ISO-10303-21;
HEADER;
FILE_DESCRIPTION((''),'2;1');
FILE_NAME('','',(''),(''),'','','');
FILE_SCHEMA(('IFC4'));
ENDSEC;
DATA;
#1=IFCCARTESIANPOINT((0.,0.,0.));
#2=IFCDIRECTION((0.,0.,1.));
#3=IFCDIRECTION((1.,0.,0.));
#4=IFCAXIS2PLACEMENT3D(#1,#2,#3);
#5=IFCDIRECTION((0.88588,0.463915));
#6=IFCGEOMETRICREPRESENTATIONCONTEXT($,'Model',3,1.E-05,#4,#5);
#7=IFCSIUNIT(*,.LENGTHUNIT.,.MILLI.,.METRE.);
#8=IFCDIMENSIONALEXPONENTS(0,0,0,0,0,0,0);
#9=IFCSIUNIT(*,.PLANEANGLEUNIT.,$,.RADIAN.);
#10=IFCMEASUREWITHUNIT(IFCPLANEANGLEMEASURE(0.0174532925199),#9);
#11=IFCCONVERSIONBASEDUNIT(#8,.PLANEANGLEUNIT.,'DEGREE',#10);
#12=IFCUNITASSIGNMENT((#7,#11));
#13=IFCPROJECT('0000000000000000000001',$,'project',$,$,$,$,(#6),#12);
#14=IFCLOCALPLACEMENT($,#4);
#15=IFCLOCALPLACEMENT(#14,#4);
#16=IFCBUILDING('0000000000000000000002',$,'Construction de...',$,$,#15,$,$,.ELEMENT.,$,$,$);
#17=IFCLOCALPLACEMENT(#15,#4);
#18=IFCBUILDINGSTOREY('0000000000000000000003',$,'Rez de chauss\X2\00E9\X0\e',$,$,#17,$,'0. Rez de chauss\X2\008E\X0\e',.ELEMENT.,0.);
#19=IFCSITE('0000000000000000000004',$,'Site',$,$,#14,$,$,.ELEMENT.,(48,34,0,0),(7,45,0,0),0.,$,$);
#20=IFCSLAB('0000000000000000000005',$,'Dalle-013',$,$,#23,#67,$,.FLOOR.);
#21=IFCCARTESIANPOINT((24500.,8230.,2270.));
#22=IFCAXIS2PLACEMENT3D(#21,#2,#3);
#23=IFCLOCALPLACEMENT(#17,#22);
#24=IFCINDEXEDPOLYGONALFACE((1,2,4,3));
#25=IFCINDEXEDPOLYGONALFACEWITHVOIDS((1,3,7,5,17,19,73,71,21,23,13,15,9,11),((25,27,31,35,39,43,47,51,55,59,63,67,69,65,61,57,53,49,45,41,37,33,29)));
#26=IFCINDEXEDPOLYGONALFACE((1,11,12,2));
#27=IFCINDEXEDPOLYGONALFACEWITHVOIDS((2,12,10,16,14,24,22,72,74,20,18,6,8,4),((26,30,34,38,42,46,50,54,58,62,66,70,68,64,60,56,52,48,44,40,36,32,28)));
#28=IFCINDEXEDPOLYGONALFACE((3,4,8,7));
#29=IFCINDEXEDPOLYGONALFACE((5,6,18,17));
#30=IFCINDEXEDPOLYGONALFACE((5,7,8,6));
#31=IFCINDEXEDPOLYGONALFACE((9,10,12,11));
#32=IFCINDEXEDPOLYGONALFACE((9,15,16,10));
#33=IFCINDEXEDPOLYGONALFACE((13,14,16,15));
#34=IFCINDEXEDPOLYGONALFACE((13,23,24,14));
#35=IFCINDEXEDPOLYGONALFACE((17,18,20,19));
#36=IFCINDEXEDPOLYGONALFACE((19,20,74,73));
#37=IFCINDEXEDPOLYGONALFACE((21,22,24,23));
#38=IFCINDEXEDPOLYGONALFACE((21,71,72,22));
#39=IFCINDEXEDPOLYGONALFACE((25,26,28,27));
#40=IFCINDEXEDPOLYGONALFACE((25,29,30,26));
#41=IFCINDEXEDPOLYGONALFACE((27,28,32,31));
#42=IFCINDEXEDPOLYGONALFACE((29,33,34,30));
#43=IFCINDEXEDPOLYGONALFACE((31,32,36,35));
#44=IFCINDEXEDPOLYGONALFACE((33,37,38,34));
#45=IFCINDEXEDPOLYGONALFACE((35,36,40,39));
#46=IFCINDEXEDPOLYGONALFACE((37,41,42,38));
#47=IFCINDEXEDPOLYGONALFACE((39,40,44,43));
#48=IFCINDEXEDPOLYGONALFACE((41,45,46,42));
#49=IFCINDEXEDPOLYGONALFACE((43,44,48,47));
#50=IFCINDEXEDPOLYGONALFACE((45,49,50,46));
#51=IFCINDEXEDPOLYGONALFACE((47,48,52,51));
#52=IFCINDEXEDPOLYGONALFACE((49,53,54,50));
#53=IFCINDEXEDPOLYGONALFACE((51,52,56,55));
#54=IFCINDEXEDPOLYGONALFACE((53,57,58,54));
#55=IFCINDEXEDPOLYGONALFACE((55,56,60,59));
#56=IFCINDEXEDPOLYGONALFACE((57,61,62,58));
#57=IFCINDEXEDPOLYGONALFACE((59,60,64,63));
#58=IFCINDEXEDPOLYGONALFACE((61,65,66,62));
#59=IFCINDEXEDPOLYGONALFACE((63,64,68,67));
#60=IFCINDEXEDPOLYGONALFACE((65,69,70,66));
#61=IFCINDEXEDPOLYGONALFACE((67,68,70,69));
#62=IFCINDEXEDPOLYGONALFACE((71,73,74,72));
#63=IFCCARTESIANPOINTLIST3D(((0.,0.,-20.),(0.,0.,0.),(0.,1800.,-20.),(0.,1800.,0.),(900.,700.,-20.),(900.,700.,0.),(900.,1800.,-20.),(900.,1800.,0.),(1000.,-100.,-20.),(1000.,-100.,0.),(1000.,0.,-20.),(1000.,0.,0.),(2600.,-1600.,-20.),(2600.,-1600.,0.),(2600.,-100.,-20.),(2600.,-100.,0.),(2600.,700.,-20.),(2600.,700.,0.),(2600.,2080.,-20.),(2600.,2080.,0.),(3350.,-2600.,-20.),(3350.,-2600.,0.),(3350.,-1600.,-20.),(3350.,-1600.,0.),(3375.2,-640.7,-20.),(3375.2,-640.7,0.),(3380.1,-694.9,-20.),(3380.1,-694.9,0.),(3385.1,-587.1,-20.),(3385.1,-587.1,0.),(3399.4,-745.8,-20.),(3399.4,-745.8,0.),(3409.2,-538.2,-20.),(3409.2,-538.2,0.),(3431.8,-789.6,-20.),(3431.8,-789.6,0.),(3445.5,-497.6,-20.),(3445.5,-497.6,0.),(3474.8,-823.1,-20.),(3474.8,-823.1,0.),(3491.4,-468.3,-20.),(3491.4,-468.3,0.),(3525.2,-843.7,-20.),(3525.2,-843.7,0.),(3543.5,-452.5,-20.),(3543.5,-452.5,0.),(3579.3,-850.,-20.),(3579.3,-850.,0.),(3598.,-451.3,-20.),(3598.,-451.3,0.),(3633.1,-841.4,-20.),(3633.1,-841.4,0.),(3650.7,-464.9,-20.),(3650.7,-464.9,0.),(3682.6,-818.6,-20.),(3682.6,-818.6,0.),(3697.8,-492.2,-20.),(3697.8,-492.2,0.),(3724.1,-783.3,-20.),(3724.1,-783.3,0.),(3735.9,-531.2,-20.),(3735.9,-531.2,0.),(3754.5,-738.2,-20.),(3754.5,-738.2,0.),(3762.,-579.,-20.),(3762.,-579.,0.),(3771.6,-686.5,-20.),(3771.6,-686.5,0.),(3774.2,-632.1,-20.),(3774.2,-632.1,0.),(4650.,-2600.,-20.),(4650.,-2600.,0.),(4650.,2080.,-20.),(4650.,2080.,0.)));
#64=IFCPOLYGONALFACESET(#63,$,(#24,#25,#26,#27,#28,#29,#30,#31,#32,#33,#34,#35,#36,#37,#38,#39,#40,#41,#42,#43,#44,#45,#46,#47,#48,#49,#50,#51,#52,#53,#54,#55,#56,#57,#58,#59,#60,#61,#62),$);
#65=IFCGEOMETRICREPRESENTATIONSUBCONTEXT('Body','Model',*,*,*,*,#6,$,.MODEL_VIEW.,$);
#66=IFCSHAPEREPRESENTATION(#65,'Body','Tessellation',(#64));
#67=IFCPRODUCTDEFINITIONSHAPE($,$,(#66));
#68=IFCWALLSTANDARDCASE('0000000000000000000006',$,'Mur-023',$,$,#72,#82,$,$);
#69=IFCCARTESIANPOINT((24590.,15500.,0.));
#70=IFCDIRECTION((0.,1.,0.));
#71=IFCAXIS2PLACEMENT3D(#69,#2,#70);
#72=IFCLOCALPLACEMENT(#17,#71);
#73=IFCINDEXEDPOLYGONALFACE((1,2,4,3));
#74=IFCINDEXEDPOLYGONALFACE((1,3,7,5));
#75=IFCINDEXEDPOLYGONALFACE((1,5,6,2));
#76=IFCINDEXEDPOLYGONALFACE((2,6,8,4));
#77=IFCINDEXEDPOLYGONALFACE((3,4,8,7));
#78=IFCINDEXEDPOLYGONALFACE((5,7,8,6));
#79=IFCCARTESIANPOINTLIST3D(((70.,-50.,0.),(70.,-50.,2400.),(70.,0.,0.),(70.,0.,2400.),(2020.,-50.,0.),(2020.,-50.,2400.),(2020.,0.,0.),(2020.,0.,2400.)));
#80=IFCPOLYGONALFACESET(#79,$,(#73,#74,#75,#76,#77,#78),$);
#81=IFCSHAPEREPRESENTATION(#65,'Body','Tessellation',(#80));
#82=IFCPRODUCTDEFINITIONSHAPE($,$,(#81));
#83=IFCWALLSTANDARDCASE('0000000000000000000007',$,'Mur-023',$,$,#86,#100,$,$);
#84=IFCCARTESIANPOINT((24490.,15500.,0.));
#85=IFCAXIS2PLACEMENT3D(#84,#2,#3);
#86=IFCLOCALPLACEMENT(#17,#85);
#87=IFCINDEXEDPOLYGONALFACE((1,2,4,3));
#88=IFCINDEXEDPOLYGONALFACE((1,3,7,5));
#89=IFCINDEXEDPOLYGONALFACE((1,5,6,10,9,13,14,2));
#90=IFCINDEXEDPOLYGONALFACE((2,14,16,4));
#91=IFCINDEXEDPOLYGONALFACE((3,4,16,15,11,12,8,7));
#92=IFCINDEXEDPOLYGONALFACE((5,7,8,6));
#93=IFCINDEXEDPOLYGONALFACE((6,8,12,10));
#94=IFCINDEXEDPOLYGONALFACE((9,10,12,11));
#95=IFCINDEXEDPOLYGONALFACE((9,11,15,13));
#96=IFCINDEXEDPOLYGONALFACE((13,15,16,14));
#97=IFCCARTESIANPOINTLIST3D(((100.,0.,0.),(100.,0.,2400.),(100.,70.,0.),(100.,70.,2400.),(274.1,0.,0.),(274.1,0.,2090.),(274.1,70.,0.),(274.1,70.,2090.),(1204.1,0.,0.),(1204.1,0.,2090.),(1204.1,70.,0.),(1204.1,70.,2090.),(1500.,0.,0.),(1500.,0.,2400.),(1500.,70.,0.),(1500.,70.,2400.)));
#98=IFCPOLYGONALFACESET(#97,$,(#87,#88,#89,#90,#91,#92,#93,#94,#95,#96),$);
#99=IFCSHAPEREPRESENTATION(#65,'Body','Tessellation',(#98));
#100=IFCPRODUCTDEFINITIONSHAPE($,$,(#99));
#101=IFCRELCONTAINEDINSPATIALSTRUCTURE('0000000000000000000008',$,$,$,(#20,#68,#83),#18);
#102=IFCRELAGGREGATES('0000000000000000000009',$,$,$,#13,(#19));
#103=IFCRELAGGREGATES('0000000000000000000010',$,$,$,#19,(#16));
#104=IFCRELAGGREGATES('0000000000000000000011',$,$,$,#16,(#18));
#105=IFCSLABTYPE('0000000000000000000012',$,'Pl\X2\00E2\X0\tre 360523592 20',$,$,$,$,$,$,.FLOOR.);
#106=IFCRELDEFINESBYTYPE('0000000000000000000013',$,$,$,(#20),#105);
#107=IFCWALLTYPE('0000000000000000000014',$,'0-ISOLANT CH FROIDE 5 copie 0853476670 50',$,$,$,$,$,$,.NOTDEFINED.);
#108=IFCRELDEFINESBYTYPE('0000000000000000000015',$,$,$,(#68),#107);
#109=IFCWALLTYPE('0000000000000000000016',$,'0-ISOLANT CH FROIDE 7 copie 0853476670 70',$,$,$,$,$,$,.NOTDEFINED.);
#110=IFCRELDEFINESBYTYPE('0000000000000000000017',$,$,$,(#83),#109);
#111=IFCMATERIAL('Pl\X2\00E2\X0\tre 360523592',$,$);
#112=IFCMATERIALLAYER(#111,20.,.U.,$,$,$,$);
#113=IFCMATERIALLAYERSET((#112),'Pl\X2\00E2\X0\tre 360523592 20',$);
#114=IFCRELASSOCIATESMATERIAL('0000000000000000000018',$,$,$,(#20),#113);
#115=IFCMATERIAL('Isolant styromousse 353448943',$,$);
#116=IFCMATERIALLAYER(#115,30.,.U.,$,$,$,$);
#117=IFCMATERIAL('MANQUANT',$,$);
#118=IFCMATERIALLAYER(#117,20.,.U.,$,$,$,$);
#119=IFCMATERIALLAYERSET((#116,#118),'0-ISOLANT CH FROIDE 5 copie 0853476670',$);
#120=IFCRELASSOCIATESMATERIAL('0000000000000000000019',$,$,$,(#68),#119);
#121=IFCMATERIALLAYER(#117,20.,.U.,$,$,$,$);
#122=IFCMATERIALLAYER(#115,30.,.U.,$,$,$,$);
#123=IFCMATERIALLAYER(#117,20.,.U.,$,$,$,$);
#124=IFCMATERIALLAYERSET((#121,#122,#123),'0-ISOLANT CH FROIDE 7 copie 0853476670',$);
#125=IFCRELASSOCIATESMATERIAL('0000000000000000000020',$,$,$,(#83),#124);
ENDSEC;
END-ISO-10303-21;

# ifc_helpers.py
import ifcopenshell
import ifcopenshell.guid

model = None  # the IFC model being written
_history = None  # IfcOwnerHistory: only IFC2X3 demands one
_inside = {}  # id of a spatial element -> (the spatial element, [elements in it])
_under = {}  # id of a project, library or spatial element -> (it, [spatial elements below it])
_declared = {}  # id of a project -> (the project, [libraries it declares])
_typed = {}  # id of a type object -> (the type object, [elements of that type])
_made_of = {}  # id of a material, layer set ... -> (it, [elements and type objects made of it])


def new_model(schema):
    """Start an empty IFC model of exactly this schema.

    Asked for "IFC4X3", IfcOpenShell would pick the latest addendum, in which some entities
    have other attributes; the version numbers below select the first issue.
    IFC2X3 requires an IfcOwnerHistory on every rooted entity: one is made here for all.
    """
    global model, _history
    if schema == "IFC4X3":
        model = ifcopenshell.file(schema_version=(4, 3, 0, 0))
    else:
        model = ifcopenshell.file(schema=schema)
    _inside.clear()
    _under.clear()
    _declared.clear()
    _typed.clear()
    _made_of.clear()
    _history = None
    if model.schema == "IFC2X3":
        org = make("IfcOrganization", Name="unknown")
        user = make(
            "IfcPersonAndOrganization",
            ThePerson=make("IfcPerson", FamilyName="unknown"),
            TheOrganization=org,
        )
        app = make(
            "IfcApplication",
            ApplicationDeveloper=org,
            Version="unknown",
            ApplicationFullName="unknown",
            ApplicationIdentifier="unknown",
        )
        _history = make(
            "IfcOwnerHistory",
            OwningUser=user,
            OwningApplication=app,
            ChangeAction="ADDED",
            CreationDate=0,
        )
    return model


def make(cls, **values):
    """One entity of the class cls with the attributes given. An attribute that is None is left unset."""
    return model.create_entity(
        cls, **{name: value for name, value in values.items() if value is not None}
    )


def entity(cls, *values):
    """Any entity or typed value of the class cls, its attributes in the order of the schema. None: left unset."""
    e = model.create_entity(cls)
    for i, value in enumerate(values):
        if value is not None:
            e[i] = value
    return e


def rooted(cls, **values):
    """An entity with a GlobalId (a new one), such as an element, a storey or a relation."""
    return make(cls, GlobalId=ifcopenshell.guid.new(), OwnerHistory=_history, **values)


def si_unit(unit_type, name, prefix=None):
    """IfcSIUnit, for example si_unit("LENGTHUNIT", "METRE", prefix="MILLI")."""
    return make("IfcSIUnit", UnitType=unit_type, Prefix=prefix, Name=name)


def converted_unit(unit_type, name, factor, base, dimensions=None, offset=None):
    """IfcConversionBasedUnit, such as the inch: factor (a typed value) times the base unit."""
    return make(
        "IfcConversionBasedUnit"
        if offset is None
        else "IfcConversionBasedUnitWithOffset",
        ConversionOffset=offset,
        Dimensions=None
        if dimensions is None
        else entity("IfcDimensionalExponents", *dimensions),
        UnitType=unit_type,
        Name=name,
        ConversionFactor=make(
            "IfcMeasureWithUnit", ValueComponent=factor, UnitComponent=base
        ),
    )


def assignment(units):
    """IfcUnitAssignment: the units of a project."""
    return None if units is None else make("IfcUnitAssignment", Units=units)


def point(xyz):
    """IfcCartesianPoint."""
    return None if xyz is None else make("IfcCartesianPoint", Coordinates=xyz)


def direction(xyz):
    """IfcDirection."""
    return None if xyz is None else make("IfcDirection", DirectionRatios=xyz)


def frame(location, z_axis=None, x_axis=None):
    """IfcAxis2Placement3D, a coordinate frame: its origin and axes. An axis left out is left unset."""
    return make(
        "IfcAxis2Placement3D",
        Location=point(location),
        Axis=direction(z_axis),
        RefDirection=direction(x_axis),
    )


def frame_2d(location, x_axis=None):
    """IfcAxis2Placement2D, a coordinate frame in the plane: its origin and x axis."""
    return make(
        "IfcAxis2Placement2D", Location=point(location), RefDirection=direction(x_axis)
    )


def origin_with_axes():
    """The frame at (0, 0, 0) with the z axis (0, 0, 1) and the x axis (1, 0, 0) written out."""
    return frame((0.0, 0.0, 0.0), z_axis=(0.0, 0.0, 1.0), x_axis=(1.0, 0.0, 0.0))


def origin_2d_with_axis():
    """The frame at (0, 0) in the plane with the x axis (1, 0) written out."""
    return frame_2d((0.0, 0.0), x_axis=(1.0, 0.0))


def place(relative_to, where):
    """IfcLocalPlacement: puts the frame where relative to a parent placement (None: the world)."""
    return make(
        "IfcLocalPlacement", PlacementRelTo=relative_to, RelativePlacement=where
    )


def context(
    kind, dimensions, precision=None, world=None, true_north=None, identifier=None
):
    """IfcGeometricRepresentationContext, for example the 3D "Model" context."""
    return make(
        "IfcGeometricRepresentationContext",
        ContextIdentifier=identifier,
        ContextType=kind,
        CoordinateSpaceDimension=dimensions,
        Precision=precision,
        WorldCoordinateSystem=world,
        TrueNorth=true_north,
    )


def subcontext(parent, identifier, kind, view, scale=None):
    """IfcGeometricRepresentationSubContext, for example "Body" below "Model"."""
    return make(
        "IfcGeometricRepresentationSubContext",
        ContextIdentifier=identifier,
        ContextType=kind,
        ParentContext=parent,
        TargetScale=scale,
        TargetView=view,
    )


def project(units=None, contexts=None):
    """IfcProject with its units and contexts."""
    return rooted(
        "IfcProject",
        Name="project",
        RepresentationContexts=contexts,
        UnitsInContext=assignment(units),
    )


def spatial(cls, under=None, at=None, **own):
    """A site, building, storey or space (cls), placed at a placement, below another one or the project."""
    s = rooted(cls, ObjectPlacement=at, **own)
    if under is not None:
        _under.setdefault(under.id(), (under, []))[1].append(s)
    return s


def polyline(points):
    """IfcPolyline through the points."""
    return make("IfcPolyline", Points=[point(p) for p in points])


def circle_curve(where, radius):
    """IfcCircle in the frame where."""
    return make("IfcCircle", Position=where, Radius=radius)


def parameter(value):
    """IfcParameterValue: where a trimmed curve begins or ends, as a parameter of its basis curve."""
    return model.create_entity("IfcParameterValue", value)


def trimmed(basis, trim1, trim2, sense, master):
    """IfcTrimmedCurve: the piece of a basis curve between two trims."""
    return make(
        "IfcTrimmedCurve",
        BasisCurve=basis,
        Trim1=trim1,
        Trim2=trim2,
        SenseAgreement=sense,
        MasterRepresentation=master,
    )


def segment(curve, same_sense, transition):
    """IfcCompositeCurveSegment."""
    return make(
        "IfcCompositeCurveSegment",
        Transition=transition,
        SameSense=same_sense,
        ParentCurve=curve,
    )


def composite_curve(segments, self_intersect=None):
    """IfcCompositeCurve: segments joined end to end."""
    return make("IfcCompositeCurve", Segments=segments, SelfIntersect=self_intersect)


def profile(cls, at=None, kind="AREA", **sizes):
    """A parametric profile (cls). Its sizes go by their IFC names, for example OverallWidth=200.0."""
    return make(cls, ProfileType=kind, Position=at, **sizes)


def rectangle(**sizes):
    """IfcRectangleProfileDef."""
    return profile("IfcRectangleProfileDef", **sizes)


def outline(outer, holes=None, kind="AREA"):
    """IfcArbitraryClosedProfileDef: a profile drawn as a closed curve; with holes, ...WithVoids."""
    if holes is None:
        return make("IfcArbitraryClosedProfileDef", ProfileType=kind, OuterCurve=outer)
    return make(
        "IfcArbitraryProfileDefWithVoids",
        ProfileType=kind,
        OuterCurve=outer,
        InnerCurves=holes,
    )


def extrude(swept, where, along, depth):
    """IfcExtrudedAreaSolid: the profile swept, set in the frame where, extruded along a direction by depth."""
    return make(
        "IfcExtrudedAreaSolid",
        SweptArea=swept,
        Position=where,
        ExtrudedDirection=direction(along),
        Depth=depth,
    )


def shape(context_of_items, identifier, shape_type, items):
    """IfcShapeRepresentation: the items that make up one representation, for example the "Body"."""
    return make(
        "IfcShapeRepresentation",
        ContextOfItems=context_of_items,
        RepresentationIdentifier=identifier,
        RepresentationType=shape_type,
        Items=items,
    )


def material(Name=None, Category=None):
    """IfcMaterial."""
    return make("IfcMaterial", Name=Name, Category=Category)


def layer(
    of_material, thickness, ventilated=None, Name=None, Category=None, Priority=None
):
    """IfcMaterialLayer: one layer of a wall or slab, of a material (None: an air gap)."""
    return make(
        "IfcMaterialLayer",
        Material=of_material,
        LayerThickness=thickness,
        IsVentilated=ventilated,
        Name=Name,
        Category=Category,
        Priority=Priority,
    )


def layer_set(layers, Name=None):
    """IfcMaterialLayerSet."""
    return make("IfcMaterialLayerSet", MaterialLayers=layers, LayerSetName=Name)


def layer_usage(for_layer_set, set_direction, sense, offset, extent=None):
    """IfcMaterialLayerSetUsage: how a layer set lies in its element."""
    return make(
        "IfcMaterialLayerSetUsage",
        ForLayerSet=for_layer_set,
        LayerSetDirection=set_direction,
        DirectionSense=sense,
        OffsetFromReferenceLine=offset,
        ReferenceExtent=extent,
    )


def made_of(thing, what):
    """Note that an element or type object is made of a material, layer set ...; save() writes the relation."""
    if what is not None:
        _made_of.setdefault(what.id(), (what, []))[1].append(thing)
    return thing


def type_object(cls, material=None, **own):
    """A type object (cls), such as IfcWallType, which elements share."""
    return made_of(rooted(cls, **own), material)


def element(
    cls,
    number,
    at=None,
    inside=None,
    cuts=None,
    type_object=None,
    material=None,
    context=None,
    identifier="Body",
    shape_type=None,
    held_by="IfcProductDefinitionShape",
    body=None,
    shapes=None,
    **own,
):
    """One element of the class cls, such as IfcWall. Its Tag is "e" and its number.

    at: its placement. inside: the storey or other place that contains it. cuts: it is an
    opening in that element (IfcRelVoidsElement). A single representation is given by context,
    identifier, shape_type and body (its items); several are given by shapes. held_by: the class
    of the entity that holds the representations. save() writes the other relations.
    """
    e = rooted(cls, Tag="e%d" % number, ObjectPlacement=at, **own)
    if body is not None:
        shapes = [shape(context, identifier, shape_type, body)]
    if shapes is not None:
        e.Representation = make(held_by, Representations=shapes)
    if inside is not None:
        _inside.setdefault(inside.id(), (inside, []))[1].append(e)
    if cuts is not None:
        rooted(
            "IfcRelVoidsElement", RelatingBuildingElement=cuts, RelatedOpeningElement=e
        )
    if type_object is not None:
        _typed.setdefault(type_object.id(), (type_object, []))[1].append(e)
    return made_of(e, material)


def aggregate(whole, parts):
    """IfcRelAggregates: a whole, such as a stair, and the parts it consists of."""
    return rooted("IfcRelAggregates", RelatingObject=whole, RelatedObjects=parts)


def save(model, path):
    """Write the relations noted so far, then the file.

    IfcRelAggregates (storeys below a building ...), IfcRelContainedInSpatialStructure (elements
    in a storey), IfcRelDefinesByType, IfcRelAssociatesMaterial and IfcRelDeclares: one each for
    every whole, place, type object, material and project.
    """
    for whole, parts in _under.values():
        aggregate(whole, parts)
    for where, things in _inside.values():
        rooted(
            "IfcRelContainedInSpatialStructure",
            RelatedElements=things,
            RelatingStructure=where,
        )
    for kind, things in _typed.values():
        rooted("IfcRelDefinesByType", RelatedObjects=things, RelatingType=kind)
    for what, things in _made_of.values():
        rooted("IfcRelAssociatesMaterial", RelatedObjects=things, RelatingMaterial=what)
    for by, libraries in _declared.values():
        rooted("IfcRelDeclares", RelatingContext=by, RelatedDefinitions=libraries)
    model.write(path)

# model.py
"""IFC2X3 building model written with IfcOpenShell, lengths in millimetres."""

from ifc_helpers import new_model, entity, si_unit, converted_unit, point, direction, frame, frame_2d, origin_with_axes, origin_2d_with_axis, place, context, subcontext, project, spatial, polyline, circle_curve, parameter, trimmed, segment, composite_curve, rectangle, outline, extrude, material, layer, layer_set, layer_usage, type_object, element, save


model = new_model("IFC2X3")

# Units and contexts
model_context = context("Model", 3, precision=1e-05, world=origin_with_axes(), true_north=direction((0.88588, 0.463915)))
body_context = subcontext(model_context, "Body", "Model", "MODEL_VIEW")
ifc_project = project(units=[si_unit("LENGTHUNIT", "METRE", prefix="MILLI"), converted_unit("PLANEANGLEUNIT", "DEGREE", entity("IfcPlaneAngleMeasure", 0.0174532925199), si_unit("PLANEANGLEUNIT", "RADIAN"), dimensions=[0, 0, 0, 0, 0, 0, 0])], contexts=[model_context])

# Site, building, storey
site_placement = place(None, origin_with_axes())
site = spatial("IfcSite", under=ifc_project, at=site_placement, Name="Site", CompositionType="ELEMENT", RefLatitude=(48, 34, 0, 0), RefLongitude=(7, 45, 0, 0), RefElevation=0.0)
building_placement = place(site_placement, origin_with_axes())
building = spatial("IfcBuilding", under=site, at=building_placement, Name="Construction de...", CompositionType="ELEMENT")
storey_placement = place(building_placement, origin_with_axes())
storey = spatial("IfcBuildingStorey", under=building, at=storey_placement, Name="Rez de chaussée", LongName="0. Rez de chauss\u008ee", CompositionType="ELEMENT", Elevation=0.0)

# Slab, opening
ifc_material_1 = material(Name="Plâtre 360523592")
ifc_layer_1 = layer(ifc_material_1, 20.0, ventilated="UNKNOWN")
ifc_layer_set_1 = layer_set([ifc_layer_1], Name="Plâtre 360523592 20")
ifc_layer_usage_1 = layer_usage(ifc_layer_set_1, "AXIS3", "NEGATIVE", 20.0)
slab_type_1 = type_object("IfcSlabType", Name="Plâtre 360523592 20", PredefinedType="FLOOR")
slab_1_placement = place(storey_placement, frame((24500.0, 8230.0, 2270.0), z_axis=(0.0, 0.0, 1.0), x_axis=(1.0, 0.0, 0.0)))
slab_1 = element("IfcSlab", 1, at=slab_1_placement, inside=storey, type_object=slab_type_1, material=ifc_layer_usage_1, Name="Dalle-013", PredefinedType="FLOOR", context=body_context, shape_type="SweptSolid", body=[
    extrude(outline(polyline([(0.0, 0.0), (1000.0, 0.0), (1000.0, -100.0), (2600.0, -100.0), (2600.0, -1600.0), (3350.0, -1600.0), (3350.0, -2600.0), (4650.0, -2600.0), (4650.0, 2080.0), (2600.0, 2080.0), (2600.0, 700.0), (900.0, 700.0), (900.0, 1800.0), (0.0, 1800.0), (0.0, 0.0)])), frame((0.0, 0.0, -20.0), z_axis=(0.0, 0.0, 1.0), x_axis=(1.0, 0.0, 0.0)), (0.0, 0.0, 1.0), 20.0),
])
opening_1_placement = place(slab_1_placement, origin_with_axes())
element("IfcOpeningElement", 2, at=opening_1_placement, cuts=slab_1, context=body_context, shape_type="SweptSolid", body=[
    extrude(outline(composite_curve([segment(trimmed(circle_curve(frame_2d((3575.0, -650.0), x_axis=(0.961298, -0.275512)), 200.0), [point((3767.3, -705.1)), parameter(0.0)], [point((3491.2, -468.4)), parameter(130.774696)], True, "CARTESIAN"), True, "CONTINUOUS"), segment(trimmed(circle_curve(frame_2d((3575.0, -650.0), x_axis=(-0.41917, 0.907908)), 200.0), [point((3491.2, -468.4)), parameter(0.0)], [point((3399.4, -745.8)), parameter(93.842903)], True, "CARTESIAN"), True, "CONTINUOUS"), segment(trimmed(circle_curve(frame_2d((3575.0, -650.0), x_axis=(-0.877773, -0.479076)), 200.0), [point((3399.4, -745.8)), parameter(0.0)], [point((3767.3, -705.1)), parameter(135.382402)], True, "CARTESIAN"), True, "CONTINUOUS")], self_intersect=False)), frame((0.0, 0.0, -20.0), z_axis=(0.0, 0.0, 1.0), x_axis=(1.0, 0.0, 0.0)), (0.0, 0.0, 1.0), 20.0),
])

# Shared definitions
ifc_material_2 = material(Name="Isolant styromousse 353448943")

# Wall
ifc_layer_2 = layer(ifc_material_2, 30.0, ventilated="UNKNOWN")
ifc_material_3 = material(Name="MANQUANT")
ifc_layer_3 = layer(ifc_material_3, 20.0, ventilated="UNKNOWN")
ifc_layer_set_2 = layer_set([ifc_layer_2, ifc_layer_3], Name="0-ISOLANT CH FROIDE 5 copie 0853476670")
wall_type_1 = type_object("IfcWallType", Name="0-ISOLANT CH FROIDE 5 copie 0853476670 50", PredefinedType="NOTDEFINED")
ifc_layer_usage_2 = layer_usage(ifc_layer_set_2, "AXIS2", "NEGATIVE", 0.0)
wall_1_placement = place(storey_placement, frame((24590.0, 15500.0, 0.0), z_axis=(0.0, 0.0, 1.0), x_axis=(0.0, 1.0, 0.0)))
element("IfcWallStandardCase", 3, at=wall_1_placement, inside=storey, type_object=wall_type_1, material=ifc_layer_usage_2, Name="Mur-023", context=body_context, shape_type="SweptSolid", body=[
    extrude(outline(polyline([(70.0, -50.0), (2020.0, -50.0), (2020.0, 0.0), (70.0, 0.0), (70.0, -50.0)])), origin_with_axes(), (0.0, 0.0, 1.0), 2400.0),
])

# Wall, opening
ifc_layer_4 = layer(ifc_material_3, 20.0, ventilated="UNKNOWN")
ifc_layer_5 = layer(ifc_material_2, 30.0, ventilated="UNKNOWN")
ifc_layer_6 = layer(ifc_material_3, 20.0, ventilated="UNKNOWN")
ifc_layer_set_3 = layer_set([ifc_layer_4, ifc_layer_5, ifc_layer_6], Name="0-ISOLANT CH FROIDE 7 copie 0853476670")
ifc_layer_usage_3 = layer_usage(ifc_layer_set_3, "AXIS2", "POSITIVE", 0.0)
wall_type_2 = type_object("IfcWallType", Name="0-ISOLANT CH FROIDE 7 copie 0853476670 70", PredefinedType="NOTDEFINED")
wall_2_placement = place(storey_placement, frame((24490.0, 15500.0, 0.0), z_axis=(0.0, 0.0, 1.0), x_axis=(1.0, 0.0, 0.0)))
wall_2 = element("IfcWallStandardCase", 4, at=wall_2_placement, inside=storey, type_object=wall_type_2, material=ifc_layer_usage_3, Name="Mur-023", context=body_context, shape_type="SweptSolid", body=[
    extrude(outline(polyline([(100.0, 0.0), (1500.0, 0.0), (1500.0, 70.0), (100.0, 70.0), (100.0, 0.0)])), origin_with_axes(), (0.0, 0.0, 1.0), 2400.0),
])
opening_2_placement = place(wall_2_placement, frame((739.1, 0.0, 0.0), z_axis=(0.0, 0.0, 1.0), x_axis=(1.0, 0.0, 0.0)))
element("IfcOpeningElement", 5, at=opening_2_placement, cuts=wall_2, context=body_context, shape_type="SweptSolid", body=[
    extrude(rectangle(XDim=930.0, YDim=2090.0, at=origin_2d_with_axis()), frame((0.0, 70.0, 1045.0), z_axis=(0.0, 1.0, 0.0), x_axis=(1.0, 0.0, 0.0)), (0.0, 0.0, -1.0), 210.0),
])

save(model, "model.ifc")
